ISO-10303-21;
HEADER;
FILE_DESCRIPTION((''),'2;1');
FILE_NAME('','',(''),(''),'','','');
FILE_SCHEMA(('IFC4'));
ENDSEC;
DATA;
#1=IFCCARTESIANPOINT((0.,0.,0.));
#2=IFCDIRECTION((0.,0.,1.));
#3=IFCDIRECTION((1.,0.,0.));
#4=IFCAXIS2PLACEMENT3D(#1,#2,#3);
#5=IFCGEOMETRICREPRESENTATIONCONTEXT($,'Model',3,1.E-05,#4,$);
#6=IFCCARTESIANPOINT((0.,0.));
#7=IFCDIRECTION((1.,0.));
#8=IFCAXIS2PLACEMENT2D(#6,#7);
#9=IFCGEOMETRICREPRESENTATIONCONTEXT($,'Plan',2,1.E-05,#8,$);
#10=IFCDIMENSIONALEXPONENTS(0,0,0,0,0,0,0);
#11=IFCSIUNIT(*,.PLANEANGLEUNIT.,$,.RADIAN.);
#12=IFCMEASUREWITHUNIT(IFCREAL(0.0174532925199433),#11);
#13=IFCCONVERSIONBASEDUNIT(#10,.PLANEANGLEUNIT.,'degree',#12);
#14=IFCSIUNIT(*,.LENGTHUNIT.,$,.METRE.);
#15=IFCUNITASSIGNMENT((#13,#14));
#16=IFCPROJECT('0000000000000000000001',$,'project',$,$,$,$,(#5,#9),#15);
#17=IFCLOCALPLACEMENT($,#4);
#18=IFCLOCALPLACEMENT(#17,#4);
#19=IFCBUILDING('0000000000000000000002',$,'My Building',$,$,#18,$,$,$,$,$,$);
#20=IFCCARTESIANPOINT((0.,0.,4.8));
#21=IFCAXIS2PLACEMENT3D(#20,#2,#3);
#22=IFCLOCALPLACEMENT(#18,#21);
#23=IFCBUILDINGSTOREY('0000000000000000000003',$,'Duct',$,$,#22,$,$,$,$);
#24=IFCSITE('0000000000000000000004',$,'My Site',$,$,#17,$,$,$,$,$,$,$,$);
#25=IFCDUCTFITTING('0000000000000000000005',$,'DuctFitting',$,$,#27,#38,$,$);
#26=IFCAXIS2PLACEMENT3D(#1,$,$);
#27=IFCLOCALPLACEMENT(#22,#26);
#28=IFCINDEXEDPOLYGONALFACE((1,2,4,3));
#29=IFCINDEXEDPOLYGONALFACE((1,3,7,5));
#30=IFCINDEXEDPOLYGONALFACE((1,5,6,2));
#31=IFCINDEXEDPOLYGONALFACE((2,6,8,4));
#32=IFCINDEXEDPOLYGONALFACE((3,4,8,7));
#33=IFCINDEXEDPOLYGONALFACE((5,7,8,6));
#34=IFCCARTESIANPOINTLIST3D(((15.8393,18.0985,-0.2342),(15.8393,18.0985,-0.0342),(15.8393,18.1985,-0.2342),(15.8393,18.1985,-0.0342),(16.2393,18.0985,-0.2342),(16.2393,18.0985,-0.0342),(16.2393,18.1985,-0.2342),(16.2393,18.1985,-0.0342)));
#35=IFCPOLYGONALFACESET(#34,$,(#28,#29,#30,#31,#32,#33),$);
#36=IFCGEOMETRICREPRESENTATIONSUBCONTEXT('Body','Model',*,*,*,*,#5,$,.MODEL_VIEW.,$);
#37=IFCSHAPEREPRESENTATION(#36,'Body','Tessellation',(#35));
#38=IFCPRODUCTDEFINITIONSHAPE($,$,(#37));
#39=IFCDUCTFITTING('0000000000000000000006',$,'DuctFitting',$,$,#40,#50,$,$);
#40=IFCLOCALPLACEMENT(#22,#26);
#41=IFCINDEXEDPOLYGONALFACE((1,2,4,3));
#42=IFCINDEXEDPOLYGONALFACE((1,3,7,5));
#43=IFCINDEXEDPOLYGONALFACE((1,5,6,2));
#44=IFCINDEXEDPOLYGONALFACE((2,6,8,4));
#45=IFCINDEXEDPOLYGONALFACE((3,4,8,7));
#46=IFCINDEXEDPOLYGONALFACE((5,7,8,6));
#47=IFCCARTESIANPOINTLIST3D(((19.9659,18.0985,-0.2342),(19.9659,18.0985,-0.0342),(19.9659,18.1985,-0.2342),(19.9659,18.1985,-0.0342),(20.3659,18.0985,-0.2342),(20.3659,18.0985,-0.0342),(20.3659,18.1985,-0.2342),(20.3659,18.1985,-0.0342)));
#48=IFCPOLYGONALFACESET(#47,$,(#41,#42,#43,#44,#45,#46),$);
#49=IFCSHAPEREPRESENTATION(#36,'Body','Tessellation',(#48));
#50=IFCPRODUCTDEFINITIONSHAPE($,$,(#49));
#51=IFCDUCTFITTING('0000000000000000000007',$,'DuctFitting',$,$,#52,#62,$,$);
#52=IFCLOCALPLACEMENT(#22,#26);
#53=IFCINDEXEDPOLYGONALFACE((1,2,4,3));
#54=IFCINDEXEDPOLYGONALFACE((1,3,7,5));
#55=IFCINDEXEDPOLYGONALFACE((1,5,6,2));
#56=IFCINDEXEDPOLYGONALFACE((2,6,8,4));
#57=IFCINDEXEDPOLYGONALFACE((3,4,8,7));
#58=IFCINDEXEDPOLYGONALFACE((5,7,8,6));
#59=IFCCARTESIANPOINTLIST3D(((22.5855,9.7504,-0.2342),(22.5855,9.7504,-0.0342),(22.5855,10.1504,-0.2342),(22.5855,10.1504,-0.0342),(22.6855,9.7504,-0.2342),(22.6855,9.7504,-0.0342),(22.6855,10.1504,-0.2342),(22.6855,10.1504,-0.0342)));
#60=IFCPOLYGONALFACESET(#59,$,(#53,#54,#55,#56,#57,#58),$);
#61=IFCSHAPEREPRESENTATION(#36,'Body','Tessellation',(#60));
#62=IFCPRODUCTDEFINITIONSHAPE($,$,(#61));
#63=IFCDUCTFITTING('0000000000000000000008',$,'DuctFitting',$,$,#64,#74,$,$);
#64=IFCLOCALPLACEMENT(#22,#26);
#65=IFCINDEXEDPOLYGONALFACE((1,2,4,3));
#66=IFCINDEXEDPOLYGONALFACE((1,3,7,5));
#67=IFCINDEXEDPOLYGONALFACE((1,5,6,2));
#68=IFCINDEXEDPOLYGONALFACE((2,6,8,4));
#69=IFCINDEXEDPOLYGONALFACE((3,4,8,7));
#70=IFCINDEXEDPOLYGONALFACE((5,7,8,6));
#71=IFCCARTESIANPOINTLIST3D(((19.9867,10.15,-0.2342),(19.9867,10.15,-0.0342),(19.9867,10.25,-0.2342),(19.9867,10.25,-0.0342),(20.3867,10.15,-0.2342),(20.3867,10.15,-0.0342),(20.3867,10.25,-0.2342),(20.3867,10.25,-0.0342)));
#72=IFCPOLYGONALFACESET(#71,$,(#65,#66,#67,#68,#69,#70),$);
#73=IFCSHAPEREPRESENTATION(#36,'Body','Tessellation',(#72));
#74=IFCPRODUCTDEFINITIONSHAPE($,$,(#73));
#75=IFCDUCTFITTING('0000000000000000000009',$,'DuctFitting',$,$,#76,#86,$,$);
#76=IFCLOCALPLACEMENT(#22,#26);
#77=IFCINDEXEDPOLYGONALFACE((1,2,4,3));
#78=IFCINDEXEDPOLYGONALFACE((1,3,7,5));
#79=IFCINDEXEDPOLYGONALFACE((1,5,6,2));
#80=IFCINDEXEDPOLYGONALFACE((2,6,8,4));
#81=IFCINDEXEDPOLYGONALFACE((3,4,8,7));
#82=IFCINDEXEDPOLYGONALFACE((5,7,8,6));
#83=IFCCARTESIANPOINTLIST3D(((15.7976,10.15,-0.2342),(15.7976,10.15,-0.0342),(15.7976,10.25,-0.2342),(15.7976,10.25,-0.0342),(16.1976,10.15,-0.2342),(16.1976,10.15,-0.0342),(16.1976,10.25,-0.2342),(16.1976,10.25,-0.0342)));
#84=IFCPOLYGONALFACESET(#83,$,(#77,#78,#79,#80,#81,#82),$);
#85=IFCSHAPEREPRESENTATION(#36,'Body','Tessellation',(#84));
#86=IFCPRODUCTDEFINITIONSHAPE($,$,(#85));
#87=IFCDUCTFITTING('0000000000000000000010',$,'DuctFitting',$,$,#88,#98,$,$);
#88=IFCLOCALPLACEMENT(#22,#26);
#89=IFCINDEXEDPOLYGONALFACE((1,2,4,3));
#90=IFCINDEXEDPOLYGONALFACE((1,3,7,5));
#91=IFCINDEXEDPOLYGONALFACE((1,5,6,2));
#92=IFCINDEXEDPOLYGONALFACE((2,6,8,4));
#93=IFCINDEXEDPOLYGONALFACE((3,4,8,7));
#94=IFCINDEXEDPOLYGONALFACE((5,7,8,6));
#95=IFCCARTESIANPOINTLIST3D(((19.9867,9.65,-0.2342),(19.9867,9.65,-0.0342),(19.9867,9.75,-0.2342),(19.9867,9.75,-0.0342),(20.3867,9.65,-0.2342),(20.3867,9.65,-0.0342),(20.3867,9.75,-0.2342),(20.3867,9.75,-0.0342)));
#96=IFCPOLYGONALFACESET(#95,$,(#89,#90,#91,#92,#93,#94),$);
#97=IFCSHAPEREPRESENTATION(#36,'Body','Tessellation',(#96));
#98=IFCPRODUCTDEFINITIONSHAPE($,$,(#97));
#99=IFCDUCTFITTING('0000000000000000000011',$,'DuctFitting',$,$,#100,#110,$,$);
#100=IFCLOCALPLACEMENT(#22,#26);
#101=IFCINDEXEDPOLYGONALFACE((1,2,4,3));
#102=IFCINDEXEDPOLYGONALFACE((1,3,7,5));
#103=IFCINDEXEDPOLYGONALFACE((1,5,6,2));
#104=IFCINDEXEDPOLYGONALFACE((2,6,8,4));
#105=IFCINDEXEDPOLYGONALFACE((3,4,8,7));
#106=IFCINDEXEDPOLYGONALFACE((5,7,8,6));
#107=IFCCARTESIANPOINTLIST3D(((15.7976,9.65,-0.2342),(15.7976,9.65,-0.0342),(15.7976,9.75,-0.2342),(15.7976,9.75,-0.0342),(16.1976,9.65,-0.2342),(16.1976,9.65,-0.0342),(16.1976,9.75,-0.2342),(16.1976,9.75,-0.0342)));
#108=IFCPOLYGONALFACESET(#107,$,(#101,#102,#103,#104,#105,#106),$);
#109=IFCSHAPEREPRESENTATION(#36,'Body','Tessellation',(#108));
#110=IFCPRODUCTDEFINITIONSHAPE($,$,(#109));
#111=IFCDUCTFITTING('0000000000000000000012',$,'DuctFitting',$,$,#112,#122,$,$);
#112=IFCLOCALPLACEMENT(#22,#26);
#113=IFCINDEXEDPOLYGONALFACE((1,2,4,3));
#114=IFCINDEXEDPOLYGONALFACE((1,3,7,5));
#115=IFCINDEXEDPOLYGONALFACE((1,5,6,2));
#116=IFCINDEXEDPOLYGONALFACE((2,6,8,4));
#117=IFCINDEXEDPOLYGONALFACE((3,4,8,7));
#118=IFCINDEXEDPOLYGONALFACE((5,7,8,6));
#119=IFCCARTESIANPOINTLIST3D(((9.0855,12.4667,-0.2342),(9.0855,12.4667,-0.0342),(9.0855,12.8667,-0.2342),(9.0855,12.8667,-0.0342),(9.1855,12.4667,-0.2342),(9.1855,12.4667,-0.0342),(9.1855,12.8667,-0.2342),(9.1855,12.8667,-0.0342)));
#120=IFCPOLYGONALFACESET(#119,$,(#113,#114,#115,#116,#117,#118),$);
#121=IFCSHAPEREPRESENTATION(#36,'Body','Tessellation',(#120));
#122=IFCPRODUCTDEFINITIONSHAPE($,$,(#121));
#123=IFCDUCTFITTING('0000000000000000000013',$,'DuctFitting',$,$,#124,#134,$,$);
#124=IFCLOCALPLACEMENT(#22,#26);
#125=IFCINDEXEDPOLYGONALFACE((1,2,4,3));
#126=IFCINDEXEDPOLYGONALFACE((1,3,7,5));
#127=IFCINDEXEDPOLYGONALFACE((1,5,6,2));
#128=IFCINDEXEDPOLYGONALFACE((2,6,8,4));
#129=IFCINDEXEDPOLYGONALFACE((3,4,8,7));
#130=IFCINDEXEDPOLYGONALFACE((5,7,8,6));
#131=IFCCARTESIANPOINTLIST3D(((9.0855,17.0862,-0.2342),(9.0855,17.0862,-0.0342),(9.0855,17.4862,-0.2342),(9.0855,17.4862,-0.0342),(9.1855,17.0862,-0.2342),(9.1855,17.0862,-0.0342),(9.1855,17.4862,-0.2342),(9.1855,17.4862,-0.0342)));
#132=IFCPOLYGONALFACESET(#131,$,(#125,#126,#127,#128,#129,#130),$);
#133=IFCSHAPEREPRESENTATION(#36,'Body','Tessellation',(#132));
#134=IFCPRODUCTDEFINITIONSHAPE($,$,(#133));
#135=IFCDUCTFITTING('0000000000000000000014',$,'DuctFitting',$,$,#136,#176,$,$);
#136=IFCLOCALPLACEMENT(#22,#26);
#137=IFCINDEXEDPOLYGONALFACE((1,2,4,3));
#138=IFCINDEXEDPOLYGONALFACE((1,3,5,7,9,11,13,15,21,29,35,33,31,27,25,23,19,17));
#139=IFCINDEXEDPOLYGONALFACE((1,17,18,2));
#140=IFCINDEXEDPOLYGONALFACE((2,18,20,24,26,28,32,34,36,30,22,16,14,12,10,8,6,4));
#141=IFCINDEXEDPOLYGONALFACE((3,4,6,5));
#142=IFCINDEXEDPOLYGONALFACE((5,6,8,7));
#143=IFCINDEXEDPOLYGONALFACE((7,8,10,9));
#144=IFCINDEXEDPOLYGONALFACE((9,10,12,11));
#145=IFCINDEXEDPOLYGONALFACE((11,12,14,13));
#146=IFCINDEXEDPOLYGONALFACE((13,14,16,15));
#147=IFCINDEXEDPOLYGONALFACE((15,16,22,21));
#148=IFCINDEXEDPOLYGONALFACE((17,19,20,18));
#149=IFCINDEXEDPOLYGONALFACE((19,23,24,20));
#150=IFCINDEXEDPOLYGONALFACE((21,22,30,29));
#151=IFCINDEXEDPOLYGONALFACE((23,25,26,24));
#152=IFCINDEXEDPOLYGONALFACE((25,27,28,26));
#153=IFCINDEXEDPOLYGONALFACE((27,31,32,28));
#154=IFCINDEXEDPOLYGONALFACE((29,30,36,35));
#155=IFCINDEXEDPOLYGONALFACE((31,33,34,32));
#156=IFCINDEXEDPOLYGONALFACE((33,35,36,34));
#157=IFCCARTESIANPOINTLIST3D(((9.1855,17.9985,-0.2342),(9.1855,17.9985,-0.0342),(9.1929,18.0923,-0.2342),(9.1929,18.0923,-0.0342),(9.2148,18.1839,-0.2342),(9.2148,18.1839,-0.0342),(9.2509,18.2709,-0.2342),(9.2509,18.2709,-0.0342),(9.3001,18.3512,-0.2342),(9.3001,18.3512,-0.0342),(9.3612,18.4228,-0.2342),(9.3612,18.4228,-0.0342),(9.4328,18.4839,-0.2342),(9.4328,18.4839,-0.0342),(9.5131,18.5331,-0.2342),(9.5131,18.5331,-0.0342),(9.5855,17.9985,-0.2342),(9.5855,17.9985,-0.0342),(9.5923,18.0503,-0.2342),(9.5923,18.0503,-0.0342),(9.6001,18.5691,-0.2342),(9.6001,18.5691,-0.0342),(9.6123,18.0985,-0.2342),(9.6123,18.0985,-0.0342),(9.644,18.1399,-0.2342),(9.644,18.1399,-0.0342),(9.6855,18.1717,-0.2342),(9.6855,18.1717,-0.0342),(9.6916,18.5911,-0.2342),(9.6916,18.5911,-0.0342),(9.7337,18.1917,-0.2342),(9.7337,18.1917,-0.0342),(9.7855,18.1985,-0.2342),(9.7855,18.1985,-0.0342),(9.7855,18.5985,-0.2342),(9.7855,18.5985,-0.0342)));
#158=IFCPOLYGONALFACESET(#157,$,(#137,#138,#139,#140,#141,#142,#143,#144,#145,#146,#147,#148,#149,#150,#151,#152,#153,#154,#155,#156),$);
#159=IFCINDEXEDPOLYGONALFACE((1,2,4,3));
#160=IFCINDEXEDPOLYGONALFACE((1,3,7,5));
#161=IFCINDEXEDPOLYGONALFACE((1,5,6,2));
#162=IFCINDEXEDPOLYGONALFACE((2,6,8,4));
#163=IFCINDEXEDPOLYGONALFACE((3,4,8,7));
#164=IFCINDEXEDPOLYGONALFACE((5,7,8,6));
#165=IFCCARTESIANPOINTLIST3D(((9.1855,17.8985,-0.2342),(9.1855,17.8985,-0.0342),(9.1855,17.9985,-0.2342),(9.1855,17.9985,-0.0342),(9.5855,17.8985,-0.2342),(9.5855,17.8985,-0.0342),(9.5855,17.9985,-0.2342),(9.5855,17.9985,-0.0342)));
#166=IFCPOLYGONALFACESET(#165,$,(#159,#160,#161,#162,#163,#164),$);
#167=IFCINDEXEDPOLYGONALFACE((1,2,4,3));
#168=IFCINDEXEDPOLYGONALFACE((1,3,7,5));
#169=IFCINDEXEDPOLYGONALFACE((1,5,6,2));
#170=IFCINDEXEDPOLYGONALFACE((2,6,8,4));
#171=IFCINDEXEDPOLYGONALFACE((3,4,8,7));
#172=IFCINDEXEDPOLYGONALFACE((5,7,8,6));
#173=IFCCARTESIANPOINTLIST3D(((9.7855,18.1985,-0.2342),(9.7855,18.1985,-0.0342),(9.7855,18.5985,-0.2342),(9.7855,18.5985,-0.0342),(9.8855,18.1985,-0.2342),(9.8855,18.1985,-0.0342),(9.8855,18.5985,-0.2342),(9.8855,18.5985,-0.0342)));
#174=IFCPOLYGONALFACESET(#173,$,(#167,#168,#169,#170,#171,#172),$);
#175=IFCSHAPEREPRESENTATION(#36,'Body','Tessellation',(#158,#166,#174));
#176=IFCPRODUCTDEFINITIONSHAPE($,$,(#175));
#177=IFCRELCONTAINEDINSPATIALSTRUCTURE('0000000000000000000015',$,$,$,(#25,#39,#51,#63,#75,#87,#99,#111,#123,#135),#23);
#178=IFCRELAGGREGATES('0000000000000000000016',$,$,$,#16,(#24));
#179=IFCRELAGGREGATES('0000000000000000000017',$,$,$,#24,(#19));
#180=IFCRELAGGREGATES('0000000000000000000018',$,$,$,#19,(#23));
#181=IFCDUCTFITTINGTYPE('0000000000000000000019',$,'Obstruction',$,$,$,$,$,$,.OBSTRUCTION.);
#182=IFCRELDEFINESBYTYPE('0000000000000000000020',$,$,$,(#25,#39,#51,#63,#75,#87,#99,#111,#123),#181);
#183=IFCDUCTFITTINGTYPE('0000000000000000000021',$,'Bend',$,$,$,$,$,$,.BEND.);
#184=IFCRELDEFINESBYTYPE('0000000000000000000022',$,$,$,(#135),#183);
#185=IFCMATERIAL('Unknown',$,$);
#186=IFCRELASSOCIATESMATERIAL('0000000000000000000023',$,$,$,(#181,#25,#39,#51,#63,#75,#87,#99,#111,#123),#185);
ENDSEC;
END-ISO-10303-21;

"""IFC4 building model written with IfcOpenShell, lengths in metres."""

from ifc_helpers import new_model, entity, si_unit, converted_unit, frame, origin_with_axes, origin_2d_with_axis, place, context, subcontext, project, spatial, line, arc, indexed_curve, rectangle, outline, extrude, source, transform, mapped, material, material_profile, profile_set, profile_usage, type_object, type_shapes, element, save


model = new_model("IFC4")

# Units and contexts
model_context = context("Model", 3, precision=1e-05, world=origin_with_axes())
plan_context = context("Plan", 2, precision=1e-05, world=origin_2d_with_axis())
body_context = subcontext(model_context, "Body", "Model", "MODEL_VIEW")
ifc_project = project(units=[converted_unit("PLANEANGLEUNIT", "degree", entity("IfcReal", 0.0174532925199433), si_unit("PLANEANGLEUNIT", "RADIAN"), dimensions=[0, 0, 0, 0, 0, 0, 0]), si_unit("LENGTHUNIT", "METRE")], contexts=[model_context, plan_context])

# Site, building, storey
site_placement = place(None, origin_with_axes())
site = spatial("IfcSite", under=ifc_project, at=site_placement, Name="My Site")
building_placement = place(site_placement, origin_with_axes())
building = spatial("IfcBuilding", under=site, at=building_placement, Name="My Building")
storey_placement = place(building_placement, frame((0.0, 0.0, 4.8), z_axis=(0.0, 0.0, 1.0), x_axis=(1.0, 0.0, 0.0)))
storey = spatial("IfcBuildingStorey", under=building, at=storey_placement, Name="Duct")

# Shared definitions
ifc_material = material(Name="Unknown")

# Duct fittings
ifc_material_profile_1 = material_profile(ifc_material, rectangle(XDim=0.4, YDim=0.2))
ifc_profile_set_1 = profile_set([ifc_material_profile_1])
duct_fitting_type_1 = type_object("IfcDuctFittingType", Name="Obstruction", PredefinedType="OBSTRUCTION", material=ifc_profile_set_1)
ifc_profile_usage_1 = profile_usage(ifc_profile_set_1, cardinal=5)
duct_fitting_1_placement = place(storey_placement, frame((16.0393, 18.0985, -0.1342), z_axis=(0.0, 1.0, 0.0), x_axis=(-1.0, 0.0, 0.0)))
element("IfcDuctFitting", 1, at=duct_fitting_1_placement, inside=storey, type_object=duct_fitting_type_1, material=ifc_profile_usage_1, Name="DuctFitting", context=body_context, shape_type="SweptSolid", body=[
    extrude(rectangle(XDim=0.4, YDim=0.2), origin_with_axes(), (0.0, 0.0, 1.0), 0.1),
])
ifc_profile_usage_2 = profile_usage(ifc_profile_set_1, cardinal=5)
duct_fitting_2_placement = place(storey_placement, frame((20.1659, 18.0985, -0.1342), z_axis=(0.0, 1.0, 0.0), x_axis=(-1.0, 0.0, 0.0)))
element("IfcDuctFitting", 2, at=duct_fitting_2_placement, inside=storey, type_object=duct_fitting_type_1, material=ifc_profile_usage_2, Name="DuctFitting", context=body_context, shape_type="SweptSolid", body=[
    extrude(rectangle(XDim=0.4, YDim=0.2), origin_with_axes(), (0.0, 0.0, 1.0), 0.1),
])
ifc_profile_usage_3 = profile_usage(ifc_profile_set_1, cardinal=5)
duct_fitting_3_placement = place(storey_placement, frame((22.6855, 9.9504, -0.1342), z_axis=(-1.0, 0.0, 0.0), x_axis=(0.0, -1.0, 0.0)))
element("IfcDuctFitting", 3, at=duct_fitting_3_placement, inside=storey, type_object=duct_fitting_type_1, material=ifc_profile_usage_3, Name="DuctFitting", context=body_context, shape_type="SweptSolid", body=[
    extrude(rectangle(XDim=0.4, YDim=0.2), origin_with_axes(), (0.0, 0.0, 1.0), 0.1),
])
ifc_profile_usage_4 = profile_usage(ifc_profile_set_1, cardinal=5)
duct_fitting_4_placement = place(storey_placement, frame((20.1867, 10.25, -0.1342), z_axis=(0.000001, -1.0, 0.0), x_axis=(1.0, 0.000001, 0.0)))
element("IfcDuctFitting", 4, at=duct_fitting_4_placement, inside=storey, type_object=duct_fitting_type_1, material=ifc_profile_usage_4, Name="DuctFitting", context=body_context, shape_type="SweptSolid", body=[
    extrude(rectangle(XDim=0.4, YDim=0.2), origin_with_axes(), (0.0, 0.0, 1.0), 0.1),
])
ifc_profile_usage_5 = profile_usage(ifc_profile_set_1, cardinal=5)
duct_fitting_5_placement = place(storey_placement, frame((15.9976, 10.25, -0.1342), z_axis=(0.000001, -1.0, 0.0), x_axis=(1.0, 0.000001, 0.0)))
element("IfcDuctFitting", 5, at=duct_fitting_5_placement, inside=storey, type_object=duct_fitting_type_1, material=ifc_profile_usage_5, Name="DuctFitting", context=body_context, shape_type="SweptSolid", body=[
    extrude(rectangle(XDim=0.4, YDim=0.2), origin_with_axes(), (0.0, 0.0, 1.0), 0.1),
])
ifc_profile_usage_6 = profile_usage(ifc_profile_set_1, cardinal=5)
duct_fitting_6_placement = place(storey_placement, frame((20.1867, 9.65, -0.1342), z_axis=(0.0, 1.0, 0.0), x_axis=(-1.0, 0.0, 0.0)))
element("IfcDuctFitting", 6, at=duct_fitting_6_placement, inside=storey, type_object=duct_fitting_type_1, material=ifc_profile_usage_6, Name="DuctFitting", context=body_context, shape_type="SweptSolid", body=[
    extrude(rectangle(XDim=0.4, YDim=0.2), origin_with_axes(), (0.0, 0.0, 1.0), 0.1),
])
ifc_profile_usage_7 = profile_usage(ifc_profile_set_1, cardinal=5)
duct_fitting_7_placement = place(storey_placement, frame((15.9976, 9.65, -0.1342), z_axis=(0.0, 1.0, 0.0), x_axis=(-1.0, 0.0, 0.0)))
element("IfcDuctFitting", 7, at=duct_fitting_7_placement, inside=storey, type_object=duct_fitting_type_1, material=ifc_profile_usage_7, Name="DuctFitting", context=body_context, shape_type="SweptSolid", body=[
    extrude(rectangle(XDim=0.4, YDim=0.2), origin_with_axes(), (0.0, 0.0, 1.0), 0.1),
])
ifc_profile_usage_8 = profile_usage(ifc_profile_set_1, cardinal=5)
duct_fitting_8_placement = place(storey_placement, frame((9.1855, 12.6667, -0.1342), z_axis=(-1.0, 0.0, 0.0), x_axis=(0.0, -1.0, 0.0)))
element("IfcDuctFitting", 8, at=duct_fitting_8_placement, inside=storey, type_object=duct_fitting_type_1, material=ifc_profile_usage_8, Name="DuctFitting", context=body_context, shape_type="SweptSolid", body=[
    extrude(rectangle(XDim=0.4, YDim=0.2), origin_with_axes(), (0.0, 0.0, 1.0), 0.1),
])
ifc_profile_usage_9 = profile_usage(ifc_profile_set_1, cardinal=5)
duct_fitting_9_placement = place(storey_placement, frame((9.1855, 17.2862, -0.1342), z_axis=(-1.0, 0.0, 0.0), x_axis=(0.0, -1.0, 0.0)))
element("IfcDuctFitting", 9, at=duct_fitting_9_placement, inside=storey, type_object=duct_fitting_type_1, material=ifc_profile_usage_9, Name="DuctFitting", context=body_context, shape_type="SweptSolid", body=[
    extrude(rectangle(XDim=0.4, YDim=0.2), origin_with_axes(), (0.0, 0.0, 1.0), 0.1),
])
duct_fitting_type_2 = type_object("IfcDuctFittingType", Name="Bend", PredefinedType="BEND")
shared_shape = source(origin_with_axes(), body_context, "Body", "SweptSolid", [
    extrude(outline(indexed_curve([(-0.2, 0.0), (-0.2586, -0.1414), (-0.4, -0.2), (-0.4, -0.6), (0.0243, -0.4243), (0.2, 0.0)], segments=[arc(1, 2, 3), line(3, 4), arc(4, 5, 6), line(6, 1)])), frame((0.0, -0.1, -0.1), z_axis=(0.0, -1.0, 0.0), x_axis=(1.0, 0.0, 0.0)), (0.0, 0.0, -1.0), 0.2),
    extrude(rectangle(XDim=0.4, YDim=0.2), origin_with_axes(), (0.0, 0.0, -1.0), 0.1),
    extrude(rectangle(XDim=0.4, YDim=0.2), frame((-0.4, 0.0, -0.5), z_axis=(-1.0, 0.0, 0.0), x_axis=(0.0, 0.0, -1.0)), (0.0, 0.0, 1.0), 0.1),
])
type_shapes(duct_fitting_type_2, [shared_shape])
for number, where, z_axis, x_axis, name in (
    (10, (9.3855, 17.8985, -0.1342), (0.0, -1.0, 0.0), (-1.0, 0.0, 0.0), "DuctFitting"),
):
    element("IfcDuctFitting", number, at=place(storey_placement, frame(where, z_axis=z_axis, x_axis=x_axis)), inside=storey, type_object=duct_fitting_type_2, Name=name, context=body_context, shape_type="MappedRepresentation", body=[
        mapped(shared_shape, transform((0.0, 0.0, 0.0), x_axis=(1.0, 0.0, 0.0), y_axis=(0.0, 1.0, 0.0), z_axis=(0.0, 0.0, 1.0), scale=1.0)),
    ])

save(model, "model.ifc")
